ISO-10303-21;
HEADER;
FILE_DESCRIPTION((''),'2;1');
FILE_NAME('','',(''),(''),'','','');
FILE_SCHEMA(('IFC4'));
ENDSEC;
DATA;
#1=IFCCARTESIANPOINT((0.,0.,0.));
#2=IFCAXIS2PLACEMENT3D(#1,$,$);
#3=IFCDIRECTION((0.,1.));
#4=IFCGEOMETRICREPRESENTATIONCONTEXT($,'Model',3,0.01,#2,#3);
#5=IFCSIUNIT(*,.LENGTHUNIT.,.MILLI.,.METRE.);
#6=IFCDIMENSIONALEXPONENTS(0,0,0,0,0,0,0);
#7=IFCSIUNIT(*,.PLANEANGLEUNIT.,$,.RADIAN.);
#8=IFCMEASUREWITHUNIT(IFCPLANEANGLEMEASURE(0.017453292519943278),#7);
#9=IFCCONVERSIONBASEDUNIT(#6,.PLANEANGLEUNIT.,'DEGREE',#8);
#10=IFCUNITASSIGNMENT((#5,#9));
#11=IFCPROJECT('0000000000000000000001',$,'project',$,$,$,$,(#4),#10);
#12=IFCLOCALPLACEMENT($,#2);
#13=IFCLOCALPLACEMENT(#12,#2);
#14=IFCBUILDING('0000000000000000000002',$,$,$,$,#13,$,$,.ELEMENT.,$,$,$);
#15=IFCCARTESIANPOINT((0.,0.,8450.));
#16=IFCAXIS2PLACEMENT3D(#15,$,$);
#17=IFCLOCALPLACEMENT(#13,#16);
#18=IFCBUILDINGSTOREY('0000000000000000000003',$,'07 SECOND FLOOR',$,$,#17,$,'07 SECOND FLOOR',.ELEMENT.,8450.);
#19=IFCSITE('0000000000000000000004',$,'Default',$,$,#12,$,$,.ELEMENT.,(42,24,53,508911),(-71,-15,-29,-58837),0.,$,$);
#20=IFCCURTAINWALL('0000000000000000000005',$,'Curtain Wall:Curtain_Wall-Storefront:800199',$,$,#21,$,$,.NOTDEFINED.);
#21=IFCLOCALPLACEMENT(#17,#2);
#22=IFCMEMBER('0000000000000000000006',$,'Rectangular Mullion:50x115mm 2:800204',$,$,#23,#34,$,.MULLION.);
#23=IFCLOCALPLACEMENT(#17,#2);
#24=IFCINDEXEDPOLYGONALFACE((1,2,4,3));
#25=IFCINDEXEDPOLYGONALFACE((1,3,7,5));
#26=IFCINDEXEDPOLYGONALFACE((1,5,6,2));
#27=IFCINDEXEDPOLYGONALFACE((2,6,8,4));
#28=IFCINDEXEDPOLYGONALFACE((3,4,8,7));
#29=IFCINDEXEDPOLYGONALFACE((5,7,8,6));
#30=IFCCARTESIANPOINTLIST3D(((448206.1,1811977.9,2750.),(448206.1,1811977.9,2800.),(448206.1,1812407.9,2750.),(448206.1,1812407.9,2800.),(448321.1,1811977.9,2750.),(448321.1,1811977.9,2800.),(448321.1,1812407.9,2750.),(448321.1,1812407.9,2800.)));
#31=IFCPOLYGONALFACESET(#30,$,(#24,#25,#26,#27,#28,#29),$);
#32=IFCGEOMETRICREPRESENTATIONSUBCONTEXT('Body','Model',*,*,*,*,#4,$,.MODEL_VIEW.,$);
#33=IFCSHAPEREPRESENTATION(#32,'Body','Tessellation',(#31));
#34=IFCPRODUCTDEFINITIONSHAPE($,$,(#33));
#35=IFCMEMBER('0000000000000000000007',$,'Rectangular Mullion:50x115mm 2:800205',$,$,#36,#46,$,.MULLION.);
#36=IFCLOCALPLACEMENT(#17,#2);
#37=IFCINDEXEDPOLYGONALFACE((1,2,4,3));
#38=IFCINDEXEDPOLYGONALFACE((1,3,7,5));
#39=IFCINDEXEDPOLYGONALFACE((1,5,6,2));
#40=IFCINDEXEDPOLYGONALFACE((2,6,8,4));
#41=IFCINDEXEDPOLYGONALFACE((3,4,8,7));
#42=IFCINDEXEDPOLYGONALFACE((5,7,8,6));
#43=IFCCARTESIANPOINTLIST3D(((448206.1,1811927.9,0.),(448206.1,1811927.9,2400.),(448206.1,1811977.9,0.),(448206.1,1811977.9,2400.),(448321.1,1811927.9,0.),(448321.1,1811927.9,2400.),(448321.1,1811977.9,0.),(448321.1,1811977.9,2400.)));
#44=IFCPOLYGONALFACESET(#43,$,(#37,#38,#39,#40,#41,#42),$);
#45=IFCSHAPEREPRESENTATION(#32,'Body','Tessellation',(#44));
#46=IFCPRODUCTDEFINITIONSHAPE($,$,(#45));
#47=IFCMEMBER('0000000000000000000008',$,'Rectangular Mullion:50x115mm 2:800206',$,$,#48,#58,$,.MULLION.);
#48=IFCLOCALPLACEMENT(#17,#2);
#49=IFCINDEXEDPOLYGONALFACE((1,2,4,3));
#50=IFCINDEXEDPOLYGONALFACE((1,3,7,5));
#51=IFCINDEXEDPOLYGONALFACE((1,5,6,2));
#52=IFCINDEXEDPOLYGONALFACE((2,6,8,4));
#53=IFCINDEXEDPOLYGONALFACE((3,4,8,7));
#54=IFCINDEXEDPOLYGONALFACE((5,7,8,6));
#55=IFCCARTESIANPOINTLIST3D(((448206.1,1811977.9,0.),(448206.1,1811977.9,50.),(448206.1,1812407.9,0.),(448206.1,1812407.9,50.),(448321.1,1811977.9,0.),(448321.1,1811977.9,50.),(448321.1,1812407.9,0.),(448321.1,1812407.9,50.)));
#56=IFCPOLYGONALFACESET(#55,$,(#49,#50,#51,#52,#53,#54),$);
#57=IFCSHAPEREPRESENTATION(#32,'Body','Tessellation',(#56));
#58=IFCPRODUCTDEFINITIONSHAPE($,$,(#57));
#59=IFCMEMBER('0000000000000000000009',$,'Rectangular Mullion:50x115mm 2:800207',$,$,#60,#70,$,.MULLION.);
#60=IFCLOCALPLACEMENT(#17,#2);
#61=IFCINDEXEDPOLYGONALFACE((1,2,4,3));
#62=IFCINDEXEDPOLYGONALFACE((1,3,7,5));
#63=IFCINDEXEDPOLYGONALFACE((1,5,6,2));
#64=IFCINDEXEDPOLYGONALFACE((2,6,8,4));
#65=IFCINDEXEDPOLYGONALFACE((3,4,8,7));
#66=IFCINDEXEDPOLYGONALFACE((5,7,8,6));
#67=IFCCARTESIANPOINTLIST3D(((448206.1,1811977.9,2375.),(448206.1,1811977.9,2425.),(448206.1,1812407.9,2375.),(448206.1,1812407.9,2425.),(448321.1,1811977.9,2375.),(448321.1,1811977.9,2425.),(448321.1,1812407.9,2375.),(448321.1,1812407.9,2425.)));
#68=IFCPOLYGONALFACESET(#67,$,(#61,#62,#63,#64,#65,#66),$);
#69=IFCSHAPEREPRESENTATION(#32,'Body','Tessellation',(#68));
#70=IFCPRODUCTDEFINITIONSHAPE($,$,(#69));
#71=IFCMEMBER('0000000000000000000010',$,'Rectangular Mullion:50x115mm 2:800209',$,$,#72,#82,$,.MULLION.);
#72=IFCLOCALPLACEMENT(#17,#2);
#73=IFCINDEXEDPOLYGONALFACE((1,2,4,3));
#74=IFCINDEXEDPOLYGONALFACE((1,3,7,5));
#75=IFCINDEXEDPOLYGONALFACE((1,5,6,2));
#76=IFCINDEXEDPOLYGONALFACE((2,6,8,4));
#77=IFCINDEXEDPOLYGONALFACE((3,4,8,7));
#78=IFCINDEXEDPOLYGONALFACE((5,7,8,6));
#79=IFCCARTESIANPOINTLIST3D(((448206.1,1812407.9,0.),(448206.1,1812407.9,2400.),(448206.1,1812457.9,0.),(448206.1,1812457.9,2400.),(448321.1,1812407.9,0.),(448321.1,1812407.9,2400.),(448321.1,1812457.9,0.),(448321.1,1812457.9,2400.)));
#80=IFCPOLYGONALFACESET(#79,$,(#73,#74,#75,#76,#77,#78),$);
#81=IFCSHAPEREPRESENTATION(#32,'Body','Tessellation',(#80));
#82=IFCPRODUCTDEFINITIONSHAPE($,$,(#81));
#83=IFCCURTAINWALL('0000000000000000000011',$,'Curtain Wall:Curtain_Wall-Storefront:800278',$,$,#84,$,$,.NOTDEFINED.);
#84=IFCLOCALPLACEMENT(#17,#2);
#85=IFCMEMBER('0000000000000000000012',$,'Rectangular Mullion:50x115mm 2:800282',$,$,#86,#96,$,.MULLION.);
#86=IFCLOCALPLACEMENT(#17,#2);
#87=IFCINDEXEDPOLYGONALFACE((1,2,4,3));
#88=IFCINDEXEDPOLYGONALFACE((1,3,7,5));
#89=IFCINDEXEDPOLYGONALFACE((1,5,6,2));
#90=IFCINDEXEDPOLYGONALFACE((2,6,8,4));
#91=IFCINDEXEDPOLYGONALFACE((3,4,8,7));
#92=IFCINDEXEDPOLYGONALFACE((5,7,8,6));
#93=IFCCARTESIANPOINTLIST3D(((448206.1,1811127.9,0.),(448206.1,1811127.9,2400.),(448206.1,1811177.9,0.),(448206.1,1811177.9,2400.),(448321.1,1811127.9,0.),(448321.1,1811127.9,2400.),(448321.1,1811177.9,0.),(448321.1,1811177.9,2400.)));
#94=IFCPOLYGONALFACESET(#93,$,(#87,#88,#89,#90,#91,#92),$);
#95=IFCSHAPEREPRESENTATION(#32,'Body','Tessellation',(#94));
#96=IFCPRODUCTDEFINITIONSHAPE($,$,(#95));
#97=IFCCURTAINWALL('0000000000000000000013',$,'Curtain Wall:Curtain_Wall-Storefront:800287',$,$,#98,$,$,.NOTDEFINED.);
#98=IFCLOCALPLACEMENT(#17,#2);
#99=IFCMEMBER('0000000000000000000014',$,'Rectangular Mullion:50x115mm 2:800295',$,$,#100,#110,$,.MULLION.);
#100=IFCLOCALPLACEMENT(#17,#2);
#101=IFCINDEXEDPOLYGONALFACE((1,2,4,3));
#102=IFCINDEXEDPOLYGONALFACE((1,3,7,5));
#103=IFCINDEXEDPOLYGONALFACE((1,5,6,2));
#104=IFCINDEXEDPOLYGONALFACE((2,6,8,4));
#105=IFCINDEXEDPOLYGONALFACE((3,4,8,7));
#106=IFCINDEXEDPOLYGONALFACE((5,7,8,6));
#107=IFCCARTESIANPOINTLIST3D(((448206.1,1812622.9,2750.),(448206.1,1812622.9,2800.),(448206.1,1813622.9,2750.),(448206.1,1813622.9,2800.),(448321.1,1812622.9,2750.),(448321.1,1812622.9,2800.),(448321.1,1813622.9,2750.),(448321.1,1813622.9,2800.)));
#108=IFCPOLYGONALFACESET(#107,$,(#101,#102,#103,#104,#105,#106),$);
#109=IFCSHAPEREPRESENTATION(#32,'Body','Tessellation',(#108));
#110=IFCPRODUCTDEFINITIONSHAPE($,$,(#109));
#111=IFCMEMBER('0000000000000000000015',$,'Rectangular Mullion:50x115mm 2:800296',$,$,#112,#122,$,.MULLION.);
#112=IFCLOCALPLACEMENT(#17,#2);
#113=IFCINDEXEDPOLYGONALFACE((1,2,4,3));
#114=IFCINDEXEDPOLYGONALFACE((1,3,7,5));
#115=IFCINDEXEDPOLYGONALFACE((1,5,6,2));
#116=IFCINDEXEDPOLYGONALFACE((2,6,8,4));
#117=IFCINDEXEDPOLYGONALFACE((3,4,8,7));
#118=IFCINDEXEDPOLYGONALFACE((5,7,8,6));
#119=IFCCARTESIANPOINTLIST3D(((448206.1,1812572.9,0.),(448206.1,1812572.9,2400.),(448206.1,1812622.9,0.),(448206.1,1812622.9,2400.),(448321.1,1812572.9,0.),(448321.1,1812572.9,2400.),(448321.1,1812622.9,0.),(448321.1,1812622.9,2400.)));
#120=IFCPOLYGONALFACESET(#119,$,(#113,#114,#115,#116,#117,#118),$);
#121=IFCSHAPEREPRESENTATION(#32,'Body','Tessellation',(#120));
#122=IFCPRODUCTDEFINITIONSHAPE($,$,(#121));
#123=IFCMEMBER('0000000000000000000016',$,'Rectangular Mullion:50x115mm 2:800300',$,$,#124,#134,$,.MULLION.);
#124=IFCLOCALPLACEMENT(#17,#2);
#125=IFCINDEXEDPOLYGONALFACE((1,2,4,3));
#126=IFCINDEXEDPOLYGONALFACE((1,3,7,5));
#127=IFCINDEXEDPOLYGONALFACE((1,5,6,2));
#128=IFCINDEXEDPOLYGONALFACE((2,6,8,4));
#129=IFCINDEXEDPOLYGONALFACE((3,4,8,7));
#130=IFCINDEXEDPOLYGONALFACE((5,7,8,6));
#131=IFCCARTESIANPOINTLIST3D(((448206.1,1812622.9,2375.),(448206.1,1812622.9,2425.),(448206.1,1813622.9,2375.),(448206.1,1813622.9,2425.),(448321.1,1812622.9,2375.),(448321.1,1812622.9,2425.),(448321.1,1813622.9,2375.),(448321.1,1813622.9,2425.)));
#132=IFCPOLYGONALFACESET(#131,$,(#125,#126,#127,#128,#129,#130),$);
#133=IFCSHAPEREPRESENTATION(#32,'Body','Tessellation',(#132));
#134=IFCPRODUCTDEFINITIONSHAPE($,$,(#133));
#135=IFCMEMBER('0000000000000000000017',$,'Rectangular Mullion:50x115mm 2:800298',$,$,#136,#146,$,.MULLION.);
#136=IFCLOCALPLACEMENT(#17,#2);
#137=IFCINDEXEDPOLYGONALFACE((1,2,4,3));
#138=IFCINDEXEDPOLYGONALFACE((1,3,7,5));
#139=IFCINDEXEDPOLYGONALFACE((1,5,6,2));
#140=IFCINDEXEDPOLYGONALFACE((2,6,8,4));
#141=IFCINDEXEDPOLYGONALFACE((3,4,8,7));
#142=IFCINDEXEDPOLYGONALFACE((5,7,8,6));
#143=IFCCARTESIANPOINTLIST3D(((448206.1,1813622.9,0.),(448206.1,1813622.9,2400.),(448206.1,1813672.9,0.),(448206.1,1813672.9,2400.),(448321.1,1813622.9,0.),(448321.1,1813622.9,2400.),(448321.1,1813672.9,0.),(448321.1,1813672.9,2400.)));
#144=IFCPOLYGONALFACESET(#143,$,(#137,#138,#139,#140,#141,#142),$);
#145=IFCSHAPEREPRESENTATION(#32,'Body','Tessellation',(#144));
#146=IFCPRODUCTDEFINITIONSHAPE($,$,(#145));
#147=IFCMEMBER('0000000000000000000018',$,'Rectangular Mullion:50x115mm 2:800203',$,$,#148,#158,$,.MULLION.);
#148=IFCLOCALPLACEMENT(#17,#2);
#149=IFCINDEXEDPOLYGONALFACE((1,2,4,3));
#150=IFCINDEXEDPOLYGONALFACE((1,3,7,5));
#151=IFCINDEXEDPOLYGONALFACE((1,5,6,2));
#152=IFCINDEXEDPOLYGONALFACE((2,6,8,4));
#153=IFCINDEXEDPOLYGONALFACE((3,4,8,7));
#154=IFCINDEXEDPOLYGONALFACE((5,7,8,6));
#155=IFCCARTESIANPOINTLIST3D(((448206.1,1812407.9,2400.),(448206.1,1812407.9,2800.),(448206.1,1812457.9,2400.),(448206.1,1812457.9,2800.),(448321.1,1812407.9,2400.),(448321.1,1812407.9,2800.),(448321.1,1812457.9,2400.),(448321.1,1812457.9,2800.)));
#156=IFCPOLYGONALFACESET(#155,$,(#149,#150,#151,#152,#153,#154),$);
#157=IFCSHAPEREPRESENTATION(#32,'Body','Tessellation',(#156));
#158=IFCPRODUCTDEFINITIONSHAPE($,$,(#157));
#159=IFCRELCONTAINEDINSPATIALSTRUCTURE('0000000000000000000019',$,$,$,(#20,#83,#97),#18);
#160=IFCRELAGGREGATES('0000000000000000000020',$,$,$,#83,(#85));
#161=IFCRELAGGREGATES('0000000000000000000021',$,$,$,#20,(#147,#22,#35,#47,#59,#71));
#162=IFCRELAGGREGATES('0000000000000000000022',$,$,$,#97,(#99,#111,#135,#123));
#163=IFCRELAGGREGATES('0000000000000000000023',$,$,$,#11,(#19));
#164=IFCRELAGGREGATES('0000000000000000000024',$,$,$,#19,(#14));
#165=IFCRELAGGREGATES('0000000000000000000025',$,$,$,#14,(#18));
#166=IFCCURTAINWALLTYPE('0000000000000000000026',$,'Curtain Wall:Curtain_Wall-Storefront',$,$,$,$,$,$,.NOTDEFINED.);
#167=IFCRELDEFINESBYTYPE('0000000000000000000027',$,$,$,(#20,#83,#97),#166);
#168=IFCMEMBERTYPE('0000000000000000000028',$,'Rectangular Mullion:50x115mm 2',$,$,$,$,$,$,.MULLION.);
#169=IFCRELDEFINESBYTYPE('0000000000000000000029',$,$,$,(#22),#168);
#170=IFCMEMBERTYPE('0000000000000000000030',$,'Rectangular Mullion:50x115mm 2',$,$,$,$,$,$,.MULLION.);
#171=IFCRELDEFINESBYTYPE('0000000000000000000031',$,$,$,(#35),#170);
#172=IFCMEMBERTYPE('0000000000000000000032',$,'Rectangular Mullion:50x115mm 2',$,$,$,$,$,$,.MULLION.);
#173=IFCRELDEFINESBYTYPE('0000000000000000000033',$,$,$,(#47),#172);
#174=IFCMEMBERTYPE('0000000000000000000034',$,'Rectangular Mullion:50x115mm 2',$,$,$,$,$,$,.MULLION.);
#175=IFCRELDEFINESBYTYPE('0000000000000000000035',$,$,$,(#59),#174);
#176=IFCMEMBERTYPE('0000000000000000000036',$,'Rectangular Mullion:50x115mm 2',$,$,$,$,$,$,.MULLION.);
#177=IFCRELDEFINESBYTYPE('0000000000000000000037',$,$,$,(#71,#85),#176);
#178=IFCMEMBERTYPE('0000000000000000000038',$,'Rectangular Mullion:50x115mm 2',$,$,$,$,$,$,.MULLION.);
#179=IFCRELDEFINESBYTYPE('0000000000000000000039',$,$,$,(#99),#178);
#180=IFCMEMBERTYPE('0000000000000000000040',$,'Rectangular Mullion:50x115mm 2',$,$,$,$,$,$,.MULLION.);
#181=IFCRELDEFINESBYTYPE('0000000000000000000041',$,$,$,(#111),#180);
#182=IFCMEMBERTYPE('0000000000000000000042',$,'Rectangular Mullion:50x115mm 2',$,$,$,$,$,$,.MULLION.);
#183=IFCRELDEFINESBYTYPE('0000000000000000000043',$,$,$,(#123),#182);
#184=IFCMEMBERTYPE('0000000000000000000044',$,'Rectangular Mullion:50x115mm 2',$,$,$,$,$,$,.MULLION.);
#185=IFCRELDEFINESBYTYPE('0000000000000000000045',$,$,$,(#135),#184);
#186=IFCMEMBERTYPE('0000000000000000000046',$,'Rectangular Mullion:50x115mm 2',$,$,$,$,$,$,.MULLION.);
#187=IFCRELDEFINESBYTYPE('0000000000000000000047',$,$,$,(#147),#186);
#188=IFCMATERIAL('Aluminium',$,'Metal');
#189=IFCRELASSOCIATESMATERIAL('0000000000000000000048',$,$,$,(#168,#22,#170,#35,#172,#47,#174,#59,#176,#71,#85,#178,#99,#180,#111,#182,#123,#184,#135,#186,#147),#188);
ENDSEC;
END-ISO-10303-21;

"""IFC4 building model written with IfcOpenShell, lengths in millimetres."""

from ifc_helpers import new_model, entity, si_unit, converted_unit, direction, frame, origin, place, context, subcontext, project, spatial, indexed_curve, outline, extrude, source, transform, mapped, material, type_object, type_shapes, element, aggregate, save


model = new_model("IFC4")

# Units and contexts
model_context = context("Model", 3, precision=0.01, world=origin(), true_north=direction((0.0, 1.0)))
body_context = subcontext(model_context, "Body", "Model", "MODEL_VIEW")
ifc_project = project(units=[si_unit("LENGTHUNIT", "METRE", prefix="MILLI"), converted_unit("PLANEANGLEUNIT", "DEGREE", entity("IfcPlaneAngleMeasure", 0.017453292519943278), si_unit("PLANEANGLEUNIT", "RADIAN"), dimensions=[0, 0, 0, 0, 0, 0, 0])], contexts=[model_context])

# Site, building, storey
site_placement = place(None, origin())
site = spatial("IfcSite", under=ifc_project, at=site_placement, Name="Default", CompositionType="ELEMENT", RefLatitude=(42, 24, 53, 508911), RefLongitude=(-71, -15, -29, -58837), RefElevation=0.0)
building_placement = place(site_placement, origin())
building = spatial("IfcBuilding", under=site, at=building_placement, CompositionType="ELEMENT")
storey_placement = place(building_placement, frame((0.0, 0.0, 8450.0)))
storey = spatial("IfcBuildingStorey", under=building, at=storey_placement, Name="07 SECOND FLOOR", LongName="07 SECOND FLOOR", CompositionType="ELEMENT", Elevation=8450.0)

# Curtain wall, members
curtain_wall_type = type_object("IfcCurtainWallType", Name="Curtain Wall:Curtain_Wall-Storefront", PredefinedType="NOTDEFINED")
curtain_wall_1_placement = place(storey_placement, frame((0.0, 0.0, -8450.0)))
curtain_wall_1 = element("IfcCurtainWall", 1, at=curtain_wall_1_placement, inside=storey, type_object=curtain_wall_type, Name="Curtain Wall:Curtain_Wall-Storefront:800199", PredefinedType="NOTDEFINED")
ifc_material_1 = material(Name="Aluminium", Category="Metal")
member_type_1 = type_object("IfcMemberType", Name="Rectangular Mullion:50x115mm 2", PredefinedType="MULLION", material=ifc_material_1)
shared_shape_1 = source(origin(), body_context, "Body", "SweptSolid", [
    extrude(outline(indexed_curve([(-25.0, -57.5), (25.0, -57.5), (25.0, 57.5), (-25.0, 57.5), (-25.0, -57.5)], self_intersect=False)), frame((-25.0, 0.0, -430.0), z_axis=(0.0, 0.0, 1.0), x_axis=(-1.0, 0.0, 0.0)), (0.0, 0.0, 1.0), 430.0),
])
type_shapes(member_type_1, [shared_shape_1])
member_1_placement = place(curtain_wall_1_placement, frame((448263.6, 1811977.9, 11250.0), z_axis=(0.0, -1.0, 0.0), x_axis=(0.0, 0.0, 1.0)))
member_1 = element("IfcMember", 2, at=member_1_placement, type_object=member_type_1, material=ifc_material_1, Name="Rectangular Mullion:50x115mm 2:800204", PredefinedType="MULLION", context=body_context, shape_type="MappedRepresentation", body=[
    mapped(shared_shape_1, transform((0.0, 0.0, 0.0), scale=1.0)),
])
member_type_2 = type_object("IfcMemberType", Name="Rectangular Mullion:50x115mm 2", PredefinedType="MULLION", material=ifc_material_1)
shared_shape_2 = source(origin(), body_context, "Body", "SweptSolid", [
    extrude(outline(indexed_curve([(-25.0, -57.5), (25.0, -57.5), (25.0, 57.5), (-25.0, 57.5), (-25.0, -57.5)], self_intersect=False)), frame((-25.0, 0.0, -2400.0), z_axis=(0.0, 0.0, 1.0), x_axis=(-1.0, 0.0, 0.0)), (0.0, 0.0, 1.0), 2400.0),
])
type_shapes(member_type_2, [shared_shape_2])
member_2_placement = place(curtain_wall_1_placement, frame((448263.6, 1811927.9, 8450.0), z_axis=(0.0, 0.0, -1.0), x_axis=(0.0, -1.0, 0.0)))
member_2 = element("IfcMember", 3, at=member_2_placement, type_object=member_type_2, material=ifc_material_1, Name="Rectangular Mullion:50x115mm 2:800205", PredefinedType="MULLION", context=body_context, shape_type="MappedRepresentation", body=[
    mapped(shared_shape_2, transform((0.0, 0.0, 0.0), scale=1.0)),
])
member_type_3 = type_object("IfcMemberType", Name="Rectangular Mullion:50x115mm 2", PredefinedType="MULLION", material=ifc_material_1)
shared_shape_3 = source(origin(), body_context, "Body", "SweptSolid", [
    extrude(outline(indexed_curve([(-25.0, -57.5), (25.0, -57.5), (25.0, 57.5), (-25.0, 57.5), (-25.0, -57.5)], self_intersect=False)), frame((-25.0, 0.0, -430.0), z_axis=(0.0, 0.0, 1.0), x_axis=(-1.0, 0.0, 0.0)), (0.0, 0.0, 1.0), 430.0),
])
type_shapes(member_type_3, [shared_shape_3])
member_3_placement = place(curtain_wall_1_placement, frame((448263.6, 1812407.9, 8450.0), z_axis=(0.0, 1.0, 0.0), x_axis=(0.0, 0.0, -1.0)))
member_3 = element("IfcMember", 4, at=member_3_placement, type_object=member_type_3, material=ifc_material_1, Name="Rectangular Mullion:50x115mm 2:800206", PredefinedType="MULLION", context=body_context, shape_type="MappedRepresentation", body=[
    mapped(shared_shape_3, transform((0.0, 0.0, 0.0), scale=1.0)),
])
member_type_4 = type_object("IfcMemberType", Name="Rectangular Mullion:50x115mm 2", PredefinedType="MULLION", material=ifc_material_1)
shared_shape_4 = source(origin(), body_context, "Body", "SweptSolid", [
    extrude(outline(indexed_curve([(-25.0, -57.5), (25.0, -57.5), (25.0, 57.5), (-25.0, 57.5), (-25.0, -57.5)], self_intersect=False)), frame((0.0, 0.0, -430.0), z_axis=(0.0, 0.0, 1.0), x_axis=(-1.0, 0.0, 0.0)), (0.0, 0.0, 1.0), 430.0),
])
type_shapes(member_type_4, [shared_shape_4])
member_4_placement = place(curtain_wall_1_placement, frame((448263.6, 1811977.9, 10850.0), z_axis=(0.0, -1.0, 0.0), x_axis=(0.0, 0.0, 1.0)))
member_4 = element("IfcMember", 5, at=member_4_placement, type_object=member_type_4, material=ifc_material_1, Name="Rectangular Mullion:50x115mm 2:800207", PredefinedType="MULLION", context=body_context, shape_type="MappedRepresentation", body=[
    mapped(shared_shape_4, transform((0.0, 0.0, 0.0), scale=1.0)),
])
member_type_5 = type_object("IfcMemberType", Name="Rectangular Mullion:50x115mm 2", PredefinedType="MULLION", material=ifc_material_1)
shared_shape_5 = source(origin(), body_context, "Body", "SweptSolid", [
    extrude(outline(indexed_curve([(-25.0, -57.5), (25.0, -57.5), (25.0, 57.5), (-25.0, 57.5), (-25.0, -57.5)], self_intersect=False)), frame((-25.0, 0.0, -2400.0), z_axis=(0.0, 0.0, 1.0), x_axis=(-1.0, 0.0, 0.0)), (0.0, 0.0, 1.0), 2400.0),
])
type_shapes(member_type_5, [shared_shape_5])
member_5_placement = place(curtain_wall_1_placement, frame((448263.6, 1812457.9, 10850.0), z_axis=(0.0, 0.0, 1.0), x_axis=(0.0, 1.0, 0.0)))
member_5 = element("IfcMember", 6, at=member_5_placement, type_object=member_type_5, material=ifc_material_1, Name="Rectangular Mullion:50x115mm 2:800209", PredefinedType="MULLION", context=body_context, shape_type="MappedRepresentation", body=[
    mapped(shared_shape_5, transform((0.0, 0.0, 0.0), scale=1.0)),
])

# Curtain wall, member
curtain_wall_2_placement = place(storey_placement, frame((0.0, 0.0, -8450.0)))
curtain_wall_2 = element("IfcCurtainWall", 7, at=curtain_wall_2_placement, inside=storey, type_object=curtain_wall_type, Name="Curtain Wall:Curtain_Wall-Storefront:800278", PredefinedType="NOTDEFINED")
member_6_placement = place(curtain_wall_2_placement, frame((448263.6, 1811177.9, 10850.0), z_axis=(0.0, 0.0, 1.0), x_axis=(0.0, 1.0, 0.0)))
member_6 = element("IfcMember", 8, at=member_6_placement, type_object=member_type_5, material=ifc_material_1, Name="Rectangular Mullion:50x115mm 2:800282", PredefinedType="MULLION", context=body_context, shape_type="MappedRepresentation", body=[
    mapped(shared_shape_5, transform((0.0, 0.0, 0.0), scale=1.0)),
])

# Curtain wall, members
curtain_wall_3_placement = place(storey_placement, frame((0.0, 0.0, -8450.0)))
curtain_wall_3 = element("IfcCurtainWall", 9, at=curtain_wall_3_placement, inside=storey, type_object=curtain_wall_type, Name="Curtain Wall:Curtain_Wall-Storefront:800287", PredefinedType="NOTDEFINED")
member_type_6 = type_object("IfcMemberType", Name="Rectangular Mullion:50x115mm 2", PredefinedType="MULLION", material=ifc_material_1)
shared_shape_6 = source(origin(), body_context, "Body", "SweptSolid", [
    extrude(outline(indexed_curve([(-25.0, -57.5), (25.0, -57.5), (25.0, 57.5), (-25.0, 57.5), (-25.0, -57.5)], self_intersect=False)), frame((-25.0, 0.0, -1000.0), z_axis=(0.0, 0.0, 1.0), x_axis=(-1.0, 0.0, 0.0)), (0.0, 0.0, 1.0), 1000.0),
])
type_shapes(member_type_6, [shared_shape_6])
member_7_placement = place(curtain_wall_3_placement, frame((448263.6, 1812622.9, 11250.0), z_axis=(0.0, -1.0, 0.0), x_axis=(0.0, 0.0, 1.0)))
member_7 = element("IfcMember", 10, at=member_7_placement, type_object=member_type_6, material=ifc_material_1, Name="Rectangular Mullion:50x115mm 2:800295", PredefinedType="MULLION", context=body_context, shape_type="MappedRepresentation", body=[
    mapped(shared_shape_6, transform((0.0, 0.0, 0.0), scale=1.0)),
])
member_type_7 = type_object("IfcMemberType", Name="Rectangular Mullion:50x115mm 2", PredefinedType="MULLION", material=ifc_material_1)
shared_shape_7 = source(origin(), body_context, "Body", "SweptSolid", [
    extrude(outline(indexed_curve([(-25.0, -57.5), (25.0, -57.5), (25.0, 57.5), (-25.0, 57.5), (-25.0, -57.5)], self_intersect=False)), frame((-25.0, 0.0, -2400.0), z_axis=(0.0, 0.0, 1.0), x_axis=(-1.0, 0.0, 0.0)), (0.0, 0.0, 1.0), 2400.0),
])
type_shapes(member_type_7, [shared_shape_7])
member_8_placement = place(curtain_wall_3_placement, frame((448263.6, 1812572.9, 8450.0), z_axis=(0.0, 0.0, -1.0), x_axis=(0.0, -1.0, 0.0)))
member_8 = element("IfcMember", 11, at=member_8_placement, type_object=member_type_7, material=ifc_material_1, Name="Rectangular Mullion:50x115mm 2:800296", PredefinedType="MULLION", context=body_context, shape_type="MappedRepresentation", body=[
    mapped(shared_shape_7, transform((0.0, 0.0, 0.0), scale=1.0)),
])
member_type_8 = type_object("IfcMemberType", Name="Rectangular Mullion:50x115mm 2", PredefinedType="MULLION", material=ifc_material_1)
shared_shape_8 = source(origin(), body_context, "Body", "SweptSolid", [
    extrude(outline(indexed_curve([(-25.0, -57.5), (25.0, -57.5), (25.0, 57.5), (-25.0, 57.5), (-25.0, -57.5)], self_intersect=False)), frame((0.0, 0.0, -1000.0), z_axis=(0.0, 0.0, 1.0), x_axis=(-1.0, 0.0, 0.0)), (0.0, 0.0, 1.0), 1000.0),
])
type_shapes(member_type_8, [shared_shape_8])
member_9_placement = place(curtain_wall_3_placement, frame((448263.6, 1812622.9, 10850.0), z_axis=(0.0, -1.0, 0.0), x_axis=(0.0, 0.0, 1.0)))
member_9 = element("IfcMember", 12, at=member_9_placement, type_object=member_type_8, material=ifc_material_1, Name="Rectangular Mullion:50x115mm 2:800300", PredefinedType="MULLION", context=body_context, shape_type="MappedRepresentation", body=[
    mapped(shared_shape_8, transform((0.0, 0.0, 0.0), scale=1.0)),
])
member_type_9 = type_object("IfcMemberType", Name="Rectangular Mullion:50x115mm 2", PredefinedType="MULLION", material=ifc_material_1)
shared_shape_9 = source(origin(), body_context, "Body", "SweptSolid", [
    extrude(outline(indexed_curve([(-25.0, -57.5), (25.0, -57.5), (25.0, 57.5), (-25.0, 57.5), (-25.0, -57.5)], self_intersect=False)), frame((0.0, 0.0, -2400.0), z_axis=(0.0, 0.0, 1.0), x_axis=(-1.0, 0.0, 0.0)), (0.0, 0.0, 1.0), 2400.0),
])
type_shapes(member_type_9, [shared_shape_9])
member_10_placement = place(curtain_wall_3_placement, frame((448263.6, 1813647.9, 8450.0), z_axis=(0.0, 0.0, -1.0), x_axis=(0.0, -1.0, 0.0)))
member_10 = element("IfcMember", 13, at=member_10_placement, type_object=member_type_9, material=ifc_material_1, Name="Rectangular Mullion:50x115mm 2:800298", PredefinedType="MULLION", context=body_context, shape_type="MappedRepresentation", body=[
    mapped(shared_shape_9, transform((0.0, 0.0, 0.0), scale=1.0)),
])

# Member
member_type_10 = type_object("IfcMemberType", Name="Rectangular Mullion:50x115mm 2", PredefinedType="MULLION", material=ifc_material_1)
shared_shape_10 = source(origin(), body_context, "Body", "SweptSolid", [
    extrude(outline(indexed_curve([(-25.0, -57.5), (25.0, -57.5), (25.0, 57.5), (-25.0, 57.5), (-25.0, -57.5)], self_intersect=False)), frame((-25.0, 0.0, -400.0), z_axis=(0.0, 0.0, 1.0), x_axis=(-1.0, 0.0, 0.0)), (0.0, 0.0, 1.0), 400.0),
])
type_shapes(member_type_10, [shared_shape_10])
member_11_placement = place(curtain_wall_1_placement, frame((448263.6, 1812457.9, 11250.0), z_axis=(0.0, 0.0, 1.0), x_axis=(0.0, 1.0, 0.0)))
member_11 = element("IfcMember", 14, at=member_11_placement, type_object=member_type_10, material=ifc_material_1, Name="Rectangular Mullion:50x115mm 2:800203", PredefinedType="MULLION", context=body_context, shape_type="MappedRepresentation", body=[
    mapped(shared_shape_10, transform((0.0, 0.0, 0.0), scale=1.0)),
])
aggregate(curtain_wall_2, [member_6])

aggregate(curtain_wall_1, [member_11, member_1, member_2, member_3, member_4, member_5])

aggregate(curtain_wall_3, [member_7, member_8, member_10, member_9])

save(model, "model.ifc")
